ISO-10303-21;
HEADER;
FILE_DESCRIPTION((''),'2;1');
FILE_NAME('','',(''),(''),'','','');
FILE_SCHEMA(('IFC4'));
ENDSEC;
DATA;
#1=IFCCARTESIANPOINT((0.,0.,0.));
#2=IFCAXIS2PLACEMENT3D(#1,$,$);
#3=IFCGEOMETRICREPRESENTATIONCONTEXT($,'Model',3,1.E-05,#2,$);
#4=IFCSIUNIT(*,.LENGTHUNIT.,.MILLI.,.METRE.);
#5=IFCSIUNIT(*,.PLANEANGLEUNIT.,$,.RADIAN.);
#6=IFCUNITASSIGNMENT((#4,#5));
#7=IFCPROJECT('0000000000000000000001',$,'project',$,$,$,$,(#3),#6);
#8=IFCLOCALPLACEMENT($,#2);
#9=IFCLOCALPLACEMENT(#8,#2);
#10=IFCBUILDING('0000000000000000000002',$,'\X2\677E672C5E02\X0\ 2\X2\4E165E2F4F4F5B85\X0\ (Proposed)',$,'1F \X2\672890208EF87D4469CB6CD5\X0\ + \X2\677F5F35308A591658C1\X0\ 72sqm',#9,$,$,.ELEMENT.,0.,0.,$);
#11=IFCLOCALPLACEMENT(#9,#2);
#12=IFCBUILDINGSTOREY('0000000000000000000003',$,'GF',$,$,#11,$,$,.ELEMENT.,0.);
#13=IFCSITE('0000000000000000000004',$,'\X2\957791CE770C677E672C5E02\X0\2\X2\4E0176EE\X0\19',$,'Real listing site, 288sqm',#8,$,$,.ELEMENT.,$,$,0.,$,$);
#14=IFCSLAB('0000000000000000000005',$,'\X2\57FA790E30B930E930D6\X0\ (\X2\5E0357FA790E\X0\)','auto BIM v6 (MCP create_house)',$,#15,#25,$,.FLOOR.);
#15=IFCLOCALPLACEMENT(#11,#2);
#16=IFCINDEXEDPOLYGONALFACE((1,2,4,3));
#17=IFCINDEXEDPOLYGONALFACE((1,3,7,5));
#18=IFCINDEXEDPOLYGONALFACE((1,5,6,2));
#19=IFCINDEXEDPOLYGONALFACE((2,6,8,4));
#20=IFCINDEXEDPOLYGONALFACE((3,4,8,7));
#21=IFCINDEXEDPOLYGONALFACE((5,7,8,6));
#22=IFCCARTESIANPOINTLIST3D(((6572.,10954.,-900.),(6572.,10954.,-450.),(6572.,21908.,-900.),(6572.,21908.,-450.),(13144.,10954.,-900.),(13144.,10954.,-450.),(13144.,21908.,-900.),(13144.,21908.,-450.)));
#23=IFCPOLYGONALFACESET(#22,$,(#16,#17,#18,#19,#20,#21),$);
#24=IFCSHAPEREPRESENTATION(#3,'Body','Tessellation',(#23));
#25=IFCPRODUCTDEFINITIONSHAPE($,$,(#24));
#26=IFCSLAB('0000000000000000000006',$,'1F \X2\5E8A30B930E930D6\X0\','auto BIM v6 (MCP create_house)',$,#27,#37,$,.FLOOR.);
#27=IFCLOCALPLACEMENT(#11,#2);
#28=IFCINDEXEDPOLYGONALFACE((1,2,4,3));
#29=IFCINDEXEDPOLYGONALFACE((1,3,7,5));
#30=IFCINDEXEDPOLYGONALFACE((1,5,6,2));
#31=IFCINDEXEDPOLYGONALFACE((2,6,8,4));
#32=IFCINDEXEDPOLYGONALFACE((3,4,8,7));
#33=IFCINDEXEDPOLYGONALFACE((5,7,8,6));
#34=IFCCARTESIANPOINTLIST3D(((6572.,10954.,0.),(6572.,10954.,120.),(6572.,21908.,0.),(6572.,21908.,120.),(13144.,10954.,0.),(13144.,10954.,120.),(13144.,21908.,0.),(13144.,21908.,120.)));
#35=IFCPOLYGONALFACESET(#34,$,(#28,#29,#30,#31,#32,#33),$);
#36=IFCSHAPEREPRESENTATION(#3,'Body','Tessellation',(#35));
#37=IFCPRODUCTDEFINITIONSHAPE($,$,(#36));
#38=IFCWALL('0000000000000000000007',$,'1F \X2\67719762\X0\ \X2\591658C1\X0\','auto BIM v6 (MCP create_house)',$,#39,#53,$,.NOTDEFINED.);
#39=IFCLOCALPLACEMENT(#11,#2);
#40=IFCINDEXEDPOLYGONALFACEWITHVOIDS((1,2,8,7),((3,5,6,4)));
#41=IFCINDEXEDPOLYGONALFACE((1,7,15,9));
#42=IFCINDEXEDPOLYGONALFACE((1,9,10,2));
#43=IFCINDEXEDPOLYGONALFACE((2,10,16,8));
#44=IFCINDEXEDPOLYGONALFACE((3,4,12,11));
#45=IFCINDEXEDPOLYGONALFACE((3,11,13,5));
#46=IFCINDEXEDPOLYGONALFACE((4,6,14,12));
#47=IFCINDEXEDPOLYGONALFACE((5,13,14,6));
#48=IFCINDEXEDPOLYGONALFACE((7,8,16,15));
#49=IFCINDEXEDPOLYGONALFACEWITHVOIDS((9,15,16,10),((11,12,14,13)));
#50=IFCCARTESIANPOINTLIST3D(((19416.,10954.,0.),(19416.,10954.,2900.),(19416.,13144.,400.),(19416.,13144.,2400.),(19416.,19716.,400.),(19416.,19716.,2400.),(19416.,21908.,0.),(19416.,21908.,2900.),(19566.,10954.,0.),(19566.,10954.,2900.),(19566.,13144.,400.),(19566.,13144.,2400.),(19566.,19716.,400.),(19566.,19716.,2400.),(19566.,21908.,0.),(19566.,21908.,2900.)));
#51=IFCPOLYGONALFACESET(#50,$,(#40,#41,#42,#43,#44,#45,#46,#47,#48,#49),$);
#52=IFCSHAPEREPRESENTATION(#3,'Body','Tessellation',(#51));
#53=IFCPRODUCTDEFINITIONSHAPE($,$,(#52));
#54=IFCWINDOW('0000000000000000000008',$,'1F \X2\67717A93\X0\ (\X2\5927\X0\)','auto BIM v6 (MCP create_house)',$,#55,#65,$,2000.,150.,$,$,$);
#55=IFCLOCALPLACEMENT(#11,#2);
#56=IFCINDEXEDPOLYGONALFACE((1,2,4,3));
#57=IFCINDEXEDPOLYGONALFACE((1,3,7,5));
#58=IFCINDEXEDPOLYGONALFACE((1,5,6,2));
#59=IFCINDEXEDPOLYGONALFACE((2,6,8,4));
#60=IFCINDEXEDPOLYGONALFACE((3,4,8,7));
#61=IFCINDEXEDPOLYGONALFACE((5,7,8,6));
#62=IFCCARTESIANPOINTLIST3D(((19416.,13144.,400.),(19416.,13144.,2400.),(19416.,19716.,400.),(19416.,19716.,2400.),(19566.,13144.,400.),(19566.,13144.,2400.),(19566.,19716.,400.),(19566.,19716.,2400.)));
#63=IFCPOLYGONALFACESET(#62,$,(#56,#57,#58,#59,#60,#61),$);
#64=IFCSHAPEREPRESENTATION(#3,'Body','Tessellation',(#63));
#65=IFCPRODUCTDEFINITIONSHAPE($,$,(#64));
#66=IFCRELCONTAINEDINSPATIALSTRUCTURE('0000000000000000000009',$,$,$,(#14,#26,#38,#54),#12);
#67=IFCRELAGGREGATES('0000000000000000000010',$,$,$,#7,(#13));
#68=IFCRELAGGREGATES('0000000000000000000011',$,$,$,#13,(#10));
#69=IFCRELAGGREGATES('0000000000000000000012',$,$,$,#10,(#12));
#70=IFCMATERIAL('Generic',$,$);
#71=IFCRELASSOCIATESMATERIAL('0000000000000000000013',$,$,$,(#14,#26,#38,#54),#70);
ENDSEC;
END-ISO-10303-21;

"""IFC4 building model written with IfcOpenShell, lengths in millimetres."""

from ifc_helpers import new_model, si_unit, frame, frame_2d, origin, place, context, project, spatial, rectangle, extrude, material, element, fill, save


model = new_model("IFC4")

# Units and contexts
model_context = context("Model", 3, precision=1e-05, world=origin())
ifc_project = project(units=[si_unit("LENGTHUNIT", "METRE", prefix="MILLI"), si_unit("PLANEANGLEUNIT", "RADIAN")], contexts=[model_context])

# Site, building, storey
site_placement = place(None, origin())
site = spatial("IfcSite", under=ifc_project, at=site_placement, Name="長野県松本市2丁目19", ObjectType="Real listing site, 288sqm", CompositionType="ELEMENT", RefElevation=0.0)
building_placement = place(site_placement, origin())
building = spatial("IfcBuilding", under=site, at=building_placement, Name="松本市 2世帯住宅 (Proposed)", ObjectType="1F 木造軸組構法 + 板張り外壁 72sqm", CompositionType="ELEMENT", ElevationOfRefHeight=0.0, ElevationOfTerrain=0.0)
storey_placement = place(building_placement, origin())
storey = spatial("IfcBuildingStorey", under=building, at=storey_placement, Name="GF", CompositionType="ELEMENT", Elevation=0.0)

# Slabs
ifc_material = material(Name="Generic")
slab_1_placement = place(storey_placement, frame((3286.0, 5477.0, -450.0)))
element("IfcSlab", 1, at=slab_1_placement, inside=storey, material=ifc_material, Name="基礎スラブ (布基礎)", Description="auto BIM v6 (MCP create_house)", PredefinedType="FLOOR", context=model_context, shape_type="SweptSolid", body=[
    extrude(rectangle(XDim=6572.0, YDim=10954.0, at=frame_2d((3286.0, 5477.0))), frame((3286.0, 5477.0, -450.0)), (0.0, 0.0, 1.0), 450.0),
])
slab_2_placement = place(storey_placement, frame((3286.0, 5477.0, 0.0)))
element("IfcSlab", 2, at=slab_2_placement, inside=storey, material=ifc_material, Name="1F 床スラブ", Description="auto BIM v6 (MCP create_house)", PredefinedType="FLOOR", context=model_context, shape_type="SweptSolid", body=[
    extrude(rectangle(XDim=6572.0, YDim=10954.0, at=frame_2d((3286.0, 5477.0))), frame((3286.0, 5477.0, 0.0)), (0.0, 0.0, 1.0), 120.0),
])

# Wall, opening, window
wall_1_placement = place(storey_placement, frame((9708.0, 5477.0, 0.0)))
wall_1 = element("IfcWall", 3, at=wall_1_placement, inside=storey, material=ifc_material, Name="1F 東面 外壁", Description="auto BIM v6 (MCP create_house)", PredefinedType="NOTDEFINED", context=model_context, shape_type="SweptSolid", body=[
    extrude(rectangle(XDim=150.0, YDim=10954.0, at=frame_2d((75.0, 5477.0))), frame((9708.0, 5477.0, 0.0)), (0.0, 0.0, 1.0), 2900.0),
])
opening_1_placement = place(storey_placement, frame((9708.0, 6572.0, 200.0)))
opening_1 = element("IfcOpeningElement", 4, at=opening_1_placement, cuts=wall_1, PredefinedType="NOTDEFINED", context=model_context, shape_type="SweptSolid", body=[
    extrude(rectangle(XDim=150.0, YDim=6572.0, at=frame_2d((75.0, 3286.0))), frame((9708.0, 6572.0, 200.0)), (0.0, 0.0, 1.0), 2000.0),
])
window_1_placement = place(storey_placement, frame((9708.0, 6572.0, 200.0)))
window_1 = element("IfcWindow", 5, at=window_1_placement, inside=storey, material=ifc_material, Name="1F 東窓 (大)", Description="auto BIM v6 (MCP create_house)", OverallHeight=2000.0, OverallWidth=150.0, context=model_context, shape_type="SweptSolid", body=[
    extrude(rectangle(XDim=150.0, YDim=6572.0, at=frame_2d((75.0, 3286.0))), frame((9708.0, 6572.0, 200.0)), (0.0, 0.0, 1.0), 2000.0),
])
fill(opening_1, window_1)

save(model, "model.ifc")
